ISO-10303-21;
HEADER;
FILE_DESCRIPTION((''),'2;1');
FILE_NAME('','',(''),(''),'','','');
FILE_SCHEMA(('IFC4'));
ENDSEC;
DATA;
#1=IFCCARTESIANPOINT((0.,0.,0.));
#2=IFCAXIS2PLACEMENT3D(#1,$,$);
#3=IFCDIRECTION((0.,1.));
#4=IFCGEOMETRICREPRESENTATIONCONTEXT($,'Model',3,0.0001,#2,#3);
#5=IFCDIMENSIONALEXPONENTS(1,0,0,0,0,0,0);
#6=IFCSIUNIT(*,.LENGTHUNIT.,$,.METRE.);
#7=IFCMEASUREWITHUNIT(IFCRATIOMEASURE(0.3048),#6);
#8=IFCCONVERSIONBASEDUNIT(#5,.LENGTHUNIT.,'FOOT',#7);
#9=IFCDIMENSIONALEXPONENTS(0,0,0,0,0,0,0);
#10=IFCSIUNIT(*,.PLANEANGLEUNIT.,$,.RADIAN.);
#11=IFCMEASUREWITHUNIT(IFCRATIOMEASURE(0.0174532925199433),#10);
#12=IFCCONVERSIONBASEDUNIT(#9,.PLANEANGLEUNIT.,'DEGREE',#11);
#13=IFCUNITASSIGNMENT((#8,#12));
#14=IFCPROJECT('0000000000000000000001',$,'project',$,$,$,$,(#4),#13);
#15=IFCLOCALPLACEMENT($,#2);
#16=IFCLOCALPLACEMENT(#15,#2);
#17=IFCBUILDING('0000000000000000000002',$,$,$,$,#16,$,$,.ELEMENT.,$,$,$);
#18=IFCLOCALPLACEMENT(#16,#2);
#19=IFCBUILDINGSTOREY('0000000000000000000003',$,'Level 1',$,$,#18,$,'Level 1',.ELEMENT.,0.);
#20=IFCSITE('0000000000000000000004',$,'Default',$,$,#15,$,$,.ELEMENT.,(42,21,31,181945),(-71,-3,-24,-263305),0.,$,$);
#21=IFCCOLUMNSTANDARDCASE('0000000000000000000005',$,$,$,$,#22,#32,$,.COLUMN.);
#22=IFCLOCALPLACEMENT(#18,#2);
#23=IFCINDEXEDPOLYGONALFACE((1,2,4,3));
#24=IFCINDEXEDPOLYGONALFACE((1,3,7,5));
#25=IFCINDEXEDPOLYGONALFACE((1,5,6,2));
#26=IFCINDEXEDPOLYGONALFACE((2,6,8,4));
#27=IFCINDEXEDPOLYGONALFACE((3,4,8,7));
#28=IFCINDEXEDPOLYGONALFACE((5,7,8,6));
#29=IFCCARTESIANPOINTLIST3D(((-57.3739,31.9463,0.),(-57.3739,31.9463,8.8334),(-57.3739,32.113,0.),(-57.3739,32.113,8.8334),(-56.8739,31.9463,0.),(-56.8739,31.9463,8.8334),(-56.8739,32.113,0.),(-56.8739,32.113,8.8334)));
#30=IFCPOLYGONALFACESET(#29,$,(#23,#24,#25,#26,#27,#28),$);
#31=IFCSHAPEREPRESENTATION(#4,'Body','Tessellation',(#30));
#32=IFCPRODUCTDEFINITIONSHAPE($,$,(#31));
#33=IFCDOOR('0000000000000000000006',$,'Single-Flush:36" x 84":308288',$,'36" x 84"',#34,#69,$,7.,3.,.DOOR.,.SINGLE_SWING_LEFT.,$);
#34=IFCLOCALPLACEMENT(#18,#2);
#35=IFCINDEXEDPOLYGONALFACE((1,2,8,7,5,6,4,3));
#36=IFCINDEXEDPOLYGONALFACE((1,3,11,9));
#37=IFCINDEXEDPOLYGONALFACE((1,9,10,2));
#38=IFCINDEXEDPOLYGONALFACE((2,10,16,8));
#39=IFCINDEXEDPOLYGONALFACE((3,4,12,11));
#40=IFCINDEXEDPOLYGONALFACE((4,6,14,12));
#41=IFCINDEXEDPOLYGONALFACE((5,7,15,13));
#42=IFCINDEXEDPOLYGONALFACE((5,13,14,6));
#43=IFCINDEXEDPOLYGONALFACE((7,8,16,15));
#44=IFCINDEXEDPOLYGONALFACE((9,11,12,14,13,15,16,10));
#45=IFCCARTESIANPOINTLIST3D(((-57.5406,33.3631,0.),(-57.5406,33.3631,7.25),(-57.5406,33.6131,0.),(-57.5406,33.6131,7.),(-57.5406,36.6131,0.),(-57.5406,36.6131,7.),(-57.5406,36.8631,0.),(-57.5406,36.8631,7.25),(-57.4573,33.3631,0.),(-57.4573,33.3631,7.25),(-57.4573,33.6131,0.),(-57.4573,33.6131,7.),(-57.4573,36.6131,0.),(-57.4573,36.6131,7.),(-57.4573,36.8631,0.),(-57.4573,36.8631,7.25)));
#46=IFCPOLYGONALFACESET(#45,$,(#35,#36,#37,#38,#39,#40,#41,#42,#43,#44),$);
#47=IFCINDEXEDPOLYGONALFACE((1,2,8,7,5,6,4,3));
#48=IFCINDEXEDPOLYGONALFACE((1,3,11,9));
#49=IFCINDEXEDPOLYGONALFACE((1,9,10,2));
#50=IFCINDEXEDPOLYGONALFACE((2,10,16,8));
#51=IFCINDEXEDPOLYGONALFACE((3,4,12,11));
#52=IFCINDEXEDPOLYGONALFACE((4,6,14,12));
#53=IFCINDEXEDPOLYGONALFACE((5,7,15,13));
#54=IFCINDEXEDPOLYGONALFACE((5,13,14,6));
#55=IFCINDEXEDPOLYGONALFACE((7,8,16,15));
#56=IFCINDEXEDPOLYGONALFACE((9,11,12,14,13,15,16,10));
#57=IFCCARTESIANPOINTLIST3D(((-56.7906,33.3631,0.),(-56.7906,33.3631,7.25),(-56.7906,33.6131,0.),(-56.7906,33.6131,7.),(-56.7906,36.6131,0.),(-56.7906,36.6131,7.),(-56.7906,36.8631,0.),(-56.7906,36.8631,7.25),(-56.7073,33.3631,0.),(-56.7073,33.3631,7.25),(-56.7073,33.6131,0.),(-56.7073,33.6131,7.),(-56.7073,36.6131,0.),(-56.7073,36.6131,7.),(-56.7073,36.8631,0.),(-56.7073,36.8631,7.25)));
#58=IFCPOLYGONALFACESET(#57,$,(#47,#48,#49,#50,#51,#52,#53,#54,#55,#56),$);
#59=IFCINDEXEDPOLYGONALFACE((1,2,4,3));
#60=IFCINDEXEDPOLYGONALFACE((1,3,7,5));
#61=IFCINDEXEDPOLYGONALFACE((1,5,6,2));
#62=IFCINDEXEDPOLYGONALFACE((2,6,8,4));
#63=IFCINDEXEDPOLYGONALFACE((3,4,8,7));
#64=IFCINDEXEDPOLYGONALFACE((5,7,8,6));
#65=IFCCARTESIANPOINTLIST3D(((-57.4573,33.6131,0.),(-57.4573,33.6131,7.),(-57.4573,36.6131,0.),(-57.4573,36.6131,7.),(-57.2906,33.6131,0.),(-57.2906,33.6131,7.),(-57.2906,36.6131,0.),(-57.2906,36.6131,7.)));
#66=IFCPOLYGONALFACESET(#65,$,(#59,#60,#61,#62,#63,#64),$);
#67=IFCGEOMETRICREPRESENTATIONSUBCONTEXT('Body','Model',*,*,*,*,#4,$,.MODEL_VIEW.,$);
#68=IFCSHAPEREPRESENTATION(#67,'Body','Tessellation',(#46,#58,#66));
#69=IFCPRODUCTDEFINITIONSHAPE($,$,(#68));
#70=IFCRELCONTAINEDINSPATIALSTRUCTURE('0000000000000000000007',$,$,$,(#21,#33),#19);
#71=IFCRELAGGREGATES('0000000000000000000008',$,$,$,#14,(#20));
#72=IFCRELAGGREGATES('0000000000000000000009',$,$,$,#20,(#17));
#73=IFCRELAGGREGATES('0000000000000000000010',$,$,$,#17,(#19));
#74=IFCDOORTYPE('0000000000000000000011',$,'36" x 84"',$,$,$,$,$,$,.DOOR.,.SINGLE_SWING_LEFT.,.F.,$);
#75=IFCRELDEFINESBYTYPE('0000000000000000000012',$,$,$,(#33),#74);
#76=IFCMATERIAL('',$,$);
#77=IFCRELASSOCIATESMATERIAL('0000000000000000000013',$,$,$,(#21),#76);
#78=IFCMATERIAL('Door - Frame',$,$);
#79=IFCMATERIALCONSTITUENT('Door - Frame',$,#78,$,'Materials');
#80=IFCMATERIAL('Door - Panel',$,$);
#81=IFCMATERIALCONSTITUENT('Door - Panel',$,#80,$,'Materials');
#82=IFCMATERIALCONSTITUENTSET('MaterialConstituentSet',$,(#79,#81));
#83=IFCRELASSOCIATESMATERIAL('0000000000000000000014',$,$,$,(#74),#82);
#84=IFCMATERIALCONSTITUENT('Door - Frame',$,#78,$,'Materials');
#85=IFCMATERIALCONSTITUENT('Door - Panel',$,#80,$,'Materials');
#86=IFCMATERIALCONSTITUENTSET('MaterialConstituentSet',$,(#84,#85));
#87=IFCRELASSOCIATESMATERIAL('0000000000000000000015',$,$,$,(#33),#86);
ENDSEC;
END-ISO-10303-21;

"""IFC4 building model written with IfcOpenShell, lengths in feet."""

from ifc_helpers import new_model, entity, si_unit, converted_unit, direction, frame, frame_2d, origin, place, context, subcontext, project, spatial, polyline, rectangle, outline, extrude, source, transform, mapped, material, constituent, constituent_set, type_object, type_shapes, element, save


model = new_model("IFC4")

# Units and contexts
model_context = context("Model", 3, precision=0.0001, world=origin(), true_north=direction((0.0, 1.0)))
body_context = subcontext(model_context, "Body", "Model", "MODEL_VIEW")
ifc_project = project(units=[converted_unit("LENGTHUNIT", "FOOT", entity("IfcRatioMeasure", 0.3048), si_unit("LENGTHUNIT", "METRE"), dimensions=[1, 0, 0, 0, 0, 0, 0]), converted_unit("PLANEANGLEUNIT", "DEGREE", entity("IfcRatioMeasure", 0.0174532925199433), si_unit("PLANEANGLEUNIT", "RADIAN"), dimensions=[0, 0, 0, 0, 0, 0, 0])], contexts=[model_context])

# Site, building, storey
site_placement = place(None, origin())
site = spatial("IfcSite", under=ifc_project, at=site_placement, Name="Default", CompositionType="ELEMENT", RefLatitude=(42, 21, 31, 181945), RefLongitude=(-71, -3, -24, -263305), RefElevation=0.0)
building_placement = place(site_placement, origin())
building = spatial("IfcBuilding", under=site, at=building_placement, CompositionType="ELEMENT")
storey_placement = place(building_placement, origin())
storey = spatial("IfcBuildingStorey", under=building, at=storey_placement, Name="Level 1", LongName="Level 1", CompositionType="ELEMENT", Elevation=0.0)

# Column
ifc_material_1 = material(Name="")
placement_1 = place(storey_placement, frame((-57.1239, 31.9464, 0.0), z_axis=(0.0, 0.0, 1.0), x_axis=(0.0, 1.0, 0.0)))
for number, where, z_axis, x_axis in (
    (1, (0.0833, 0.0, 0.0), (0.0, 0.0, 1.0), (1.0, 0.0, 0.0)),
):
    element("IfcColumnStandardCase", number, at=place(placement_1, frame(where, z_axis=z_axis, x_axis=x_axis)), inside=storey, material=ifc_material_1, PredefinedType="COLUMN", context=model_context, shape_type="SweptSolid", body=[
        extrude(rectangle(XDim=0.1667, YDim=0.5), origin(), (0.0, 0.0, 1.0), 8.8334),
    ])

# Door
ifc_material_2 = material(Name="Door - Frame")
ifc_constituent_1 = constituent(ifc_material_2, Name="Door - Frame", Category="Materials")
ifc_material_3 = material(Name="Door - Panel")
ifc_constituent_2 = constituent(ifc_material_3, Name="Door - Panel", Category="Materials")
ifc_constituent_set_1 = constituent_set(constituents=[ifc_constituent_1, ifc_constituent_2], Name="MaterialConstituentSet")
ifc_constituent_3 = constituent(ifc_material_2, Name="Door - Frame", Category="Materials")
ifc_constituent_4 = constituent(ifc_material_3, Name="Door - Panel", Category="Materials")
ifc_constituent_set_2 = constituent_set(constituents=[ifc_constituent_3, ifc_constituent_4], Name="MaterialConstituentSet")
door_type = type_object("IfcDoorType", Name="36\" x 84\"", OperationType="SINGLE_SWING_LEFT", ParameterTakesPrecedence=False, PredefinedType="DOOR", material=ifc_constituent_set_2)
shared_shape = source(origin(), body_context, "Body", "SweptSolid", [
    extrude(outline(polyline([(-1.75, -3.6875), (1.75, -3.6875), (1.75, 3.5625), (1.5, 3.5625), (1.5, -3.4375), (-1.5, -3.4375), (-1.5, 3.5625), (-1.75, 3.5625), (-1.75, -3.6875)])), frame((1.5, 0.75, 3.5625), z_axis=(0.0, -1.0, 0.0), x_axis=(-1.0, 0.0, 0.0)), (0.0, 0.0, 1.0), 0.0833),
    extrude(outline(polyline([(-3.6875, -1.75), (3.5625, -1.75), (3.5625, -1.5), (-3.4375, -1.5), (-3.4375, 1.5), (3.5625, 1.5), (3.5625, 1.75), (-3.6875, 1.75), (-3.6875, -1.75)])), frame((1.5, 0.0, 3.5625), z_axis=(0.0, -1.0, 0.0), x_axis=(0.0, 0.0, -1.0)), (0.0, 0.0, 1.0), 0.0833),
    extrude(rectangle(XDim=3.0, YDim=0.1667, at=frame_2d((0.0, 0.0), x_axis=(1.0, 0.0))), frame((1.5, 0.5833, 0.0)), (0.0, 0.0, 1.0), 7.0),
])
type_shapes(door_type, [shared_shape])
placement_2 = place(placement_1, frame((1.6667, -0.3333, 0.0)))
door_placement = place(placement_2, origin())
element("IfcDoor", 2, at=door_placement, inside=storey, type_object=door_type, material=ifc_constituent_set_1, Name="Single-Flush:36\" x 84\":308288", ObjectType="36\" x 84\"", OperationType="SINGLE_SWING_LEFT", OverallHeight=7.0, OverallWidth=3.0, PredefinedType="DOOR", context=body_context, shape_type="MappedRepresentation", body=[
    mapped(shared_shape, transform((0.0, 0.0, 0.0), scale=1.0)),
])

save(model, "model.ifc")
